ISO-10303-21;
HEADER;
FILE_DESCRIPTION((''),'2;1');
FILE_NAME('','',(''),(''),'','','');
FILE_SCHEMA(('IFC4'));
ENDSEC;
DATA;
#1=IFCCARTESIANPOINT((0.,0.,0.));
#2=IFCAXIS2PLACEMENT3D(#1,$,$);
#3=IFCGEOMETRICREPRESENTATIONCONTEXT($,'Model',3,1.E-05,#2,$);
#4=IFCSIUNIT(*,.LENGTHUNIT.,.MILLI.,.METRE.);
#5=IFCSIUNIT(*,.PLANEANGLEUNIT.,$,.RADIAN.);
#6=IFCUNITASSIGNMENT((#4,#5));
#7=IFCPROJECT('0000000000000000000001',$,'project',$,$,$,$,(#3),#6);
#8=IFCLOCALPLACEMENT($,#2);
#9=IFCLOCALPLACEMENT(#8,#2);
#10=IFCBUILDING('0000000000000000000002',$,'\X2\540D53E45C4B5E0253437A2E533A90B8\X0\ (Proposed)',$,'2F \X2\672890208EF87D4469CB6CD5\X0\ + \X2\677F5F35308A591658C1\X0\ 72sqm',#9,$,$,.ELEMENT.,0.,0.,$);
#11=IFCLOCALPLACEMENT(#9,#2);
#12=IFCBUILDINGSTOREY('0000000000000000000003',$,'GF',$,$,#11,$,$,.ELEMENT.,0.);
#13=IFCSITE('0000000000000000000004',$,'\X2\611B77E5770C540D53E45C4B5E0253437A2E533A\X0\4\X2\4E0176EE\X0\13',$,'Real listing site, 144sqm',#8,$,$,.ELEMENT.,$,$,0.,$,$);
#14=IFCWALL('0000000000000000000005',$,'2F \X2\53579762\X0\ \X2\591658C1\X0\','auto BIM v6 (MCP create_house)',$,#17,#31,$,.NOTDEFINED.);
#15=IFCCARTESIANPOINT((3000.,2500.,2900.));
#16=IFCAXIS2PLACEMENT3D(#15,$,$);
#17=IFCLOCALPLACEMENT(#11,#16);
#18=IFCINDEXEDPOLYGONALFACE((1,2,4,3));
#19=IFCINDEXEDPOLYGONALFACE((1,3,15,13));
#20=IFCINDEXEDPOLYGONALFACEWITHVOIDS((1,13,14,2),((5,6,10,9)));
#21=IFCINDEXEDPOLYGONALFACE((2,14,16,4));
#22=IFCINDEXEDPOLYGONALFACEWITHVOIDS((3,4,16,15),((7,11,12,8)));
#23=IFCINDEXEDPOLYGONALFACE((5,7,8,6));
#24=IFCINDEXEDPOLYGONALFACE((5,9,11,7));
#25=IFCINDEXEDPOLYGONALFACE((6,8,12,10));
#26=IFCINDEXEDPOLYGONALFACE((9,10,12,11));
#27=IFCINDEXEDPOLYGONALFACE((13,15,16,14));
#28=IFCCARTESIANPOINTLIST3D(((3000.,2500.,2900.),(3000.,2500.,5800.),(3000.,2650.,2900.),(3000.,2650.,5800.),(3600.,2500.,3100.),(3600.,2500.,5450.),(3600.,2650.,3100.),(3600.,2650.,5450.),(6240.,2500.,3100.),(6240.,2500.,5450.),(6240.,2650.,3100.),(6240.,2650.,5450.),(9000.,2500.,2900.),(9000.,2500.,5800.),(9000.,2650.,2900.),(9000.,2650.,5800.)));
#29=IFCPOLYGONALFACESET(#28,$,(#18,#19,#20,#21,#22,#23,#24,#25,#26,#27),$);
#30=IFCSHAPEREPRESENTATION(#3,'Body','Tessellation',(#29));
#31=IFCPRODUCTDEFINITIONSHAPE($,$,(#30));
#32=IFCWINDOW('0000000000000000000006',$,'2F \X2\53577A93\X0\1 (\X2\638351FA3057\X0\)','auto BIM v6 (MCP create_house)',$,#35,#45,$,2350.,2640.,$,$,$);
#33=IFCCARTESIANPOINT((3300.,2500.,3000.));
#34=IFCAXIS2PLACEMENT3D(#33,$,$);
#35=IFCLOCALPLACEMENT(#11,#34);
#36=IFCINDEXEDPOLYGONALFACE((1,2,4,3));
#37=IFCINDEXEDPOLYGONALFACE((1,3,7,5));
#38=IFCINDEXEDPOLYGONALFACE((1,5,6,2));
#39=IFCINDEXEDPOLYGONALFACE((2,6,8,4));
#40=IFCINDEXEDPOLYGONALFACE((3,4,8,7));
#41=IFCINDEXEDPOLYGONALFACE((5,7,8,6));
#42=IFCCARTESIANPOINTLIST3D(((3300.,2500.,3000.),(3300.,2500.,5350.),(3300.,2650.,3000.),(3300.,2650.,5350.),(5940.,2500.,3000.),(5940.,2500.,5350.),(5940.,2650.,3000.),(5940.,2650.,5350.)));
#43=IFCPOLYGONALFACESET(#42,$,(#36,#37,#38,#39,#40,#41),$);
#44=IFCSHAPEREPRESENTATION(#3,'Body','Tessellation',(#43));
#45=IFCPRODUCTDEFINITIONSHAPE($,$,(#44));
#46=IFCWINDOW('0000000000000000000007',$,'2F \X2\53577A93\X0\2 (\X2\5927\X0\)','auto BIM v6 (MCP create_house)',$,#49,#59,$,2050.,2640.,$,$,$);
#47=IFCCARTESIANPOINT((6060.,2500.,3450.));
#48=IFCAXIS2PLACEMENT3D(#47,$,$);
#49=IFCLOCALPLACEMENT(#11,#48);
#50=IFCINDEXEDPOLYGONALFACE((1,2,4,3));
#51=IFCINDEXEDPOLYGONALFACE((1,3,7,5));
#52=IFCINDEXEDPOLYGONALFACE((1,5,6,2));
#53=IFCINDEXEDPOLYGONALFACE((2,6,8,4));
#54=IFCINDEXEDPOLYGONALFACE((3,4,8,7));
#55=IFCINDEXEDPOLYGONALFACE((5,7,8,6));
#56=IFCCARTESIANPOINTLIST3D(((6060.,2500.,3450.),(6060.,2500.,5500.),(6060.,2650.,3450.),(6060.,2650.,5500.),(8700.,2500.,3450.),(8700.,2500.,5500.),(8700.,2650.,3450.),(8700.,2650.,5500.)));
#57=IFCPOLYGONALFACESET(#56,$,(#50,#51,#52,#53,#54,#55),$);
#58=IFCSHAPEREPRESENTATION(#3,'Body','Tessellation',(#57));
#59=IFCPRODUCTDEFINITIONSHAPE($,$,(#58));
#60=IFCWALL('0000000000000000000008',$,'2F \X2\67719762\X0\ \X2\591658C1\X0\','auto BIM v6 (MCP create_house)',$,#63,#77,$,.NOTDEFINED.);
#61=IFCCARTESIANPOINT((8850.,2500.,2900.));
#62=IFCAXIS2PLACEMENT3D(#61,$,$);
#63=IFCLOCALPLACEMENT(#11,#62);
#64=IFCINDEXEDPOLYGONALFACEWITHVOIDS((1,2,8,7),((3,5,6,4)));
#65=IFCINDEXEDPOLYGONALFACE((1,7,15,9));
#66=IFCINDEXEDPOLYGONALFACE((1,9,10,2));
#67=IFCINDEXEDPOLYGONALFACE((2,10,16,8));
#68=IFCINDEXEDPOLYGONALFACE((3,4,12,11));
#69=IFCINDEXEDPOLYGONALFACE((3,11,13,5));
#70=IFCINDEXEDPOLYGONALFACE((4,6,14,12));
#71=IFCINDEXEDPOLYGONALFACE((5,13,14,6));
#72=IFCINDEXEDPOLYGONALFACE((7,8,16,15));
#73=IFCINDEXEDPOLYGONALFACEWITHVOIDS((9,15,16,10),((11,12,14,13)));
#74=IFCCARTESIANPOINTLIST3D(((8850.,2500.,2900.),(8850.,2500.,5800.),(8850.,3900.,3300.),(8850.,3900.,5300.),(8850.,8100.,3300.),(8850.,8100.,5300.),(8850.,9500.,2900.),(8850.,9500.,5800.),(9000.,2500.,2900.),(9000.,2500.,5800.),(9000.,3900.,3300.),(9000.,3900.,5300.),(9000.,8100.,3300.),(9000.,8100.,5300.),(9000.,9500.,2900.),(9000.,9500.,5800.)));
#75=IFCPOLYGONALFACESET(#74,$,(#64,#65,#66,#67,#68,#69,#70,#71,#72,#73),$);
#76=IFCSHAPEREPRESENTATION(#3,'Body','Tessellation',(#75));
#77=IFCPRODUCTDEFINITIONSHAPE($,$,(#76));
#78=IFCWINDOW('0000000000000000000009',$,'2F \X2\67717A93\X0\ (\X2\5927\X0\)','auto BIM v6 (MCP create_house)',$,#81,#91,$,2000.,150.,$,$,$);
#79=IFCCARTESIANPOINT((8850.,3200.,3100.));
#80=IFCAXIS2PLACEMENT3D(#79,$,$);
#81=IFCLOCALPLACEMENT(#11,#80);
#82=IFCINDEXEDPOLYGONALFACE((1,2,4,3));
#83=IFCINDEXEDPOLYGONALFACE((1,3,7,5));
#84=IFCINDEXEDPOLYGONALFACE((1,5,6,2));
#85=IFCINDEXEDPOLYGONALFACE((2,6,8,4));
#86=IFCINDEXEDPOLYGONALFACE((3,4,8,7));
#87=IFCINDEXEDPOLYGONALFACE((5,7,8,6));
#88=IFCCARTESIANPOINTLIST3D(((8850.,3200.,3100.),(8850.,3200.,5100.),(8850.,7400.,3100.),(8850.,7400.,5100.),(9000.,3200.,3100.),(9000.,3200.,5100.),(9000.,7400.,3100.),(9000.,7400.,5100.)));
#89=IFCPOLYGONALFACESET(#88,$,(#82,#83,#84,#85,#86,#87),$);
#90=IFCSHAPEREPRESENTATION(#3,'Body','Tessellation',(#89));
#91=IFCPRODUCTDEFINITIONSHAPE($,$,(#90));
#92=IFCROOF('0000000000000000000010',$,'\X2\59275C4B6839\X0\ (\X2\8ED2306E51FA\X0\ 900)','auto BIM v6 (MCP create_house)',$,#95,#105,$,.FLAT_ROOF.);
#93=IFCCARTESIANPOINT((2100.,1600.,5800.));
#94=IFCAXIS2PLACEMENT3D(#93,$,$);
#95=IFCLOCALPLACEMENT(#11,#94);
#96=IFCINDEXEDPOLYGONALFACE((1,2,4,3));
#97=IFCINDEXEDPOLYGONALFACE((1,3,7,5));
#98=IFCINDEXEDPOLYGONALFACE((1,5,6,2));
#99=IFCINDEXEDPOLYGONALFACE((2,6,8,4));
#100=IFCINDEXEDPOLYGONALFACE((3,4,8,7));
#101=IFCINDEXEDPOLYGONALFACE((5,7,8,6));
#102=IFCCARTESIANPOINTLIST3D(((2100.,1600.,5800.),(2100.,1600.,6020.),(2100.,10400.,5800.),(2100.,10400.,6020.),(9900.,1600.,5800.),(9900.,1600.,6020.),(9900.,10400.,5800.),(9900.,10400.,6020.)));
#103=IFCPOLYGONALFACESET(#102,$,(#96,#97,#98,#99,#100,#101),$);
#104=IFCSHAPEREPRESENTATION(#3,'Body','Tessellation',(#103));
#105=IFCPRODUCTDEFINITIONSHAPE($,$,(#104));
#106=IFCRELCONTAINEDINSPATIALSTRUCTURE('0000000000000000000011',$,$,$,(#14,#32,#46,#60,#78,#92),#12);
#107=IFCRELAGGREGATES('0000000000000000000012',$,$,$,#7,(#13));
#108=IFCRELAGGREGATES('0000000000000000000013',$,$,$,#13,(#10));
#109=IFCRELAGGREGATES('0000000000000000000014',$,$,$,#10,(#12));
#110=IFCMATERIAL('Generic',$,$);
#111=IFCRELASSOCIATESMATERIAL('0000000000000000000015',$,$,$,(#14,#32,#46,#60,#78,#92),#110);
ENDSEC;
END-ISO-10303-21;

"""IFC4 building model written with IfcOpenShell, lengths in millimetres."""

from ifc_helpers import new_model, si_unit, frame, frame_2d, origin, place, context, project, spatial, rectangle, extrude, material, element, fill, save


model = new_model("IFC4")

# Units and contexts
model_context = context("Model", 3, precision=1e-05, world=origin())
ifc_project = project(units=[si_unit("LENGTHUNIT", "METRE", prefix="MILLI"), si_unit("PLANEANGLEUNIT", "RADIAN")], contexts=[model_context])

# Site, building, storey
site_placement = place(None, origin())
site = spatial("IfcSite", under=ifc_project, at=site_placement, Name="愛知県名古屋市千種区4丁目13", ObjectType="Real listing site, 144sqm", CompositionType="ELEMENT", RefElevation=0.0)
building_placement = place(site_placement, origin())
building = spatial("IfcBuilding", under=site, at=building_placement, Name="名古屋市千種区邸 (Proposed)", ObjectType="2F 木造軸組構法 + 板張り外壁 72sqm", CompositionType="ELEMENT", ElevationOfRefHeight=0.0, ElevationOfTerrain=0.0)
storey_placement = place(building_placement, origin())
storey = spatial("IfcBuildingStorey", under=building, at=storey_placement, Name="GF", CompositionType="ELEMENT", Elevation=0.0)

# Shared definitions
ifc_material = material(Name="Generic")

# Wall, openings, windows
wall_1_placement = place(storey_placement, frame((3000.0, 2500.0, 2900.0)))
wall_1 = element("IfcWall", 1, at=wall_1_placement, inside=storey, material=ifc_material, Name="2F 南面 外壁", Description="auto BIM v6 (MCP create_house)", PredefinedType="NOTDEFINED", context=model_context, shape_type="SweptSolid", body=[
    extrude(rectangle(XDim=6000.0, YDim=150.0, at=frame_2d((3000.0, 75.0))), frame((3000.0, 2500.0, 2900.0)), (0.0, 0.0, 1.0), 2900.0),
])
opening_1_placement = place(storey_placement, frame((3300.0, 2500.0, 3000.0)))
opening_1 = element("IfcOpeningElement", 2, at=opening_1_placement, cuts=wall_1, PredefinedType="NOTDEFINED", context=model_context, shape_type="SweptSolid", body=[
    extrude(rectangle(XDim=2640.0, YDim=150.0, at=frame_2d((1320.0, 75.0))), frame((3300.0, 2500.0, 3000.0)), (0.0, 0.0, 1.0), 2350.0),
])
opening_2_placement = place(storey_placement, frame((6060.0, 2500.0, 3450.0)))
opening_2 = element("IfcOpeningElement", 3, at=opening_2_placement, cuts=wall_1, PredefinedType="NOTDEFINED", context=model_context, shape_type="SweptSolid", body=[
    extrude(rectangle(XDim=2640.0, YDim=150.0, at=frame_2d((1320.0, 75.0))), frame((6060.0, 2500.0, 3450.0)), (0.0, 0.0, 1.0), 2050.0),
])
window_1_placement = place(storey_placement, frame((3300.0, 2500.0, 3000.0)))
window_1 = element("IfcWindow", 4, at=window_1_placement, inside=storey, material=ifc_material, Name="2F 南窓1 (掃出し)", Description="auto BIM v6 (MCP create_house)", OverallHeight=2350.0, OverallWidth=2640.0, context=model_context, shape_type="SweptSolid", body=[
    extrude(rectangle(XDim=2640.0, YDim=150.0, at=frame_2d((1320.0, 75.0))), frame((3300.0, 2500.0, 3000.0)), (0.0, 0.0, 1.0), 2350.0),
])
fill(opening_1, window_1)
window_2_placement = place(storey_placement, frame((6060.0, 2500.0, 3450.0)))
window_2 = element("IfcWindow", 5, at=window_2_placement, inside=storey, material=ifc_material, Name="2F 南窓2 (大)", Description="auto BIM v6 (MCP create_house)", OverallHeight=2050.0, OverallWidth=2640.0, context=model_context, shape_type="SweptSolid", body=[
    extrude(rectangle(XDim=2640.0, YDim=150.0, at=frame_2d((1320.0, 75.0))), frame((6060.0, 2500.0, 3450.0)), (0.0, 0.0, 1.0), 2050.0),
])
fill(opening_2, window_2)

# Wall, opening, window
wall_2_placement = place(storey_placement, frame((8850.0, 2500.0, 2900.0)))
wall_2 = element("IfcWall", 6, at=wall_2_placement, inside=storey, material=ifc_material, Name="2F 東面 外壁", Description="auto BIM v6 (MCP create_house)", PredefinedType="NOTDEFINED", context=model_context, shape_type="SweptSolid", body=[
    extrude(rectangle(XDim=150.0, YDim=7000.0, at=frame_2d((75.0, 3500.0))), frame((8850.0, 2500.0, 2900.0)), (0.0, 0.0, 1.0), 2900.0),
])
opening_3_placement = place(storey_placement, frame((8850.0, 3200.0, 3100.0)))
opening_3 = element("IfcOpeningElement", 7, at=opening_3_placement, cuts=wall_2, PredefinedType="NOTDEFINED", context=model_context, shape_type="SweptSolid", body=[
    extrude(rectangle(XDim=150.0, YDim=4200.0, at=frame_2d((75.0, 2100.0))), frame((8850.0, 3200.0, 3100.0)), (0.0, 0.0, 1.0), 2000.0),
])
window_3_placement = place(storey_placement, frame((8850.0, 3200.0, 3100.0)))
window_3 = element("IfcWindow", 8, at=window_3_placement, inside=storey, material=ifc_material, Name="2F 東窓 (大)", Description="auto BIM v6 (MCP create_house)", OverallHeight=2000.0, OverallWidth=150.0, context=model_context, shape_type="SweptSolid", body=[
    extrude(rectangle(XDim=150.0, YDim=4200.0, at=frame_2d((75.0, 2100.0))), frame((8850.0, 3200.0, 3100.0)), (0.0, 0.0, 1.0), 2000.0),
])
fill(opening_3, window_3)

# Roof
roof_placement = place(storey_placement, frame((2100.0, 1600.0, 5800.0)))
element("IfcRoof", 9, at=roof_placement, inside=storey, material=ifc_material, Name="大屋根 (軒の出 900)", Description="auto BIM v6 (MCP create_house)", PredefinedType="FLAT_ROOF", context=model_context, shape_type="SweptSolid", body=[
    extrude(rectangle(XDim=7800.0, YDim=8800.0, at=frame_2d((3900.0, 4400.0))), frame((2100.0, 1600.0, 5800.0)), (0.0, 0.0, 1.0), 220.0),
])

save(model, "model.ifc")
